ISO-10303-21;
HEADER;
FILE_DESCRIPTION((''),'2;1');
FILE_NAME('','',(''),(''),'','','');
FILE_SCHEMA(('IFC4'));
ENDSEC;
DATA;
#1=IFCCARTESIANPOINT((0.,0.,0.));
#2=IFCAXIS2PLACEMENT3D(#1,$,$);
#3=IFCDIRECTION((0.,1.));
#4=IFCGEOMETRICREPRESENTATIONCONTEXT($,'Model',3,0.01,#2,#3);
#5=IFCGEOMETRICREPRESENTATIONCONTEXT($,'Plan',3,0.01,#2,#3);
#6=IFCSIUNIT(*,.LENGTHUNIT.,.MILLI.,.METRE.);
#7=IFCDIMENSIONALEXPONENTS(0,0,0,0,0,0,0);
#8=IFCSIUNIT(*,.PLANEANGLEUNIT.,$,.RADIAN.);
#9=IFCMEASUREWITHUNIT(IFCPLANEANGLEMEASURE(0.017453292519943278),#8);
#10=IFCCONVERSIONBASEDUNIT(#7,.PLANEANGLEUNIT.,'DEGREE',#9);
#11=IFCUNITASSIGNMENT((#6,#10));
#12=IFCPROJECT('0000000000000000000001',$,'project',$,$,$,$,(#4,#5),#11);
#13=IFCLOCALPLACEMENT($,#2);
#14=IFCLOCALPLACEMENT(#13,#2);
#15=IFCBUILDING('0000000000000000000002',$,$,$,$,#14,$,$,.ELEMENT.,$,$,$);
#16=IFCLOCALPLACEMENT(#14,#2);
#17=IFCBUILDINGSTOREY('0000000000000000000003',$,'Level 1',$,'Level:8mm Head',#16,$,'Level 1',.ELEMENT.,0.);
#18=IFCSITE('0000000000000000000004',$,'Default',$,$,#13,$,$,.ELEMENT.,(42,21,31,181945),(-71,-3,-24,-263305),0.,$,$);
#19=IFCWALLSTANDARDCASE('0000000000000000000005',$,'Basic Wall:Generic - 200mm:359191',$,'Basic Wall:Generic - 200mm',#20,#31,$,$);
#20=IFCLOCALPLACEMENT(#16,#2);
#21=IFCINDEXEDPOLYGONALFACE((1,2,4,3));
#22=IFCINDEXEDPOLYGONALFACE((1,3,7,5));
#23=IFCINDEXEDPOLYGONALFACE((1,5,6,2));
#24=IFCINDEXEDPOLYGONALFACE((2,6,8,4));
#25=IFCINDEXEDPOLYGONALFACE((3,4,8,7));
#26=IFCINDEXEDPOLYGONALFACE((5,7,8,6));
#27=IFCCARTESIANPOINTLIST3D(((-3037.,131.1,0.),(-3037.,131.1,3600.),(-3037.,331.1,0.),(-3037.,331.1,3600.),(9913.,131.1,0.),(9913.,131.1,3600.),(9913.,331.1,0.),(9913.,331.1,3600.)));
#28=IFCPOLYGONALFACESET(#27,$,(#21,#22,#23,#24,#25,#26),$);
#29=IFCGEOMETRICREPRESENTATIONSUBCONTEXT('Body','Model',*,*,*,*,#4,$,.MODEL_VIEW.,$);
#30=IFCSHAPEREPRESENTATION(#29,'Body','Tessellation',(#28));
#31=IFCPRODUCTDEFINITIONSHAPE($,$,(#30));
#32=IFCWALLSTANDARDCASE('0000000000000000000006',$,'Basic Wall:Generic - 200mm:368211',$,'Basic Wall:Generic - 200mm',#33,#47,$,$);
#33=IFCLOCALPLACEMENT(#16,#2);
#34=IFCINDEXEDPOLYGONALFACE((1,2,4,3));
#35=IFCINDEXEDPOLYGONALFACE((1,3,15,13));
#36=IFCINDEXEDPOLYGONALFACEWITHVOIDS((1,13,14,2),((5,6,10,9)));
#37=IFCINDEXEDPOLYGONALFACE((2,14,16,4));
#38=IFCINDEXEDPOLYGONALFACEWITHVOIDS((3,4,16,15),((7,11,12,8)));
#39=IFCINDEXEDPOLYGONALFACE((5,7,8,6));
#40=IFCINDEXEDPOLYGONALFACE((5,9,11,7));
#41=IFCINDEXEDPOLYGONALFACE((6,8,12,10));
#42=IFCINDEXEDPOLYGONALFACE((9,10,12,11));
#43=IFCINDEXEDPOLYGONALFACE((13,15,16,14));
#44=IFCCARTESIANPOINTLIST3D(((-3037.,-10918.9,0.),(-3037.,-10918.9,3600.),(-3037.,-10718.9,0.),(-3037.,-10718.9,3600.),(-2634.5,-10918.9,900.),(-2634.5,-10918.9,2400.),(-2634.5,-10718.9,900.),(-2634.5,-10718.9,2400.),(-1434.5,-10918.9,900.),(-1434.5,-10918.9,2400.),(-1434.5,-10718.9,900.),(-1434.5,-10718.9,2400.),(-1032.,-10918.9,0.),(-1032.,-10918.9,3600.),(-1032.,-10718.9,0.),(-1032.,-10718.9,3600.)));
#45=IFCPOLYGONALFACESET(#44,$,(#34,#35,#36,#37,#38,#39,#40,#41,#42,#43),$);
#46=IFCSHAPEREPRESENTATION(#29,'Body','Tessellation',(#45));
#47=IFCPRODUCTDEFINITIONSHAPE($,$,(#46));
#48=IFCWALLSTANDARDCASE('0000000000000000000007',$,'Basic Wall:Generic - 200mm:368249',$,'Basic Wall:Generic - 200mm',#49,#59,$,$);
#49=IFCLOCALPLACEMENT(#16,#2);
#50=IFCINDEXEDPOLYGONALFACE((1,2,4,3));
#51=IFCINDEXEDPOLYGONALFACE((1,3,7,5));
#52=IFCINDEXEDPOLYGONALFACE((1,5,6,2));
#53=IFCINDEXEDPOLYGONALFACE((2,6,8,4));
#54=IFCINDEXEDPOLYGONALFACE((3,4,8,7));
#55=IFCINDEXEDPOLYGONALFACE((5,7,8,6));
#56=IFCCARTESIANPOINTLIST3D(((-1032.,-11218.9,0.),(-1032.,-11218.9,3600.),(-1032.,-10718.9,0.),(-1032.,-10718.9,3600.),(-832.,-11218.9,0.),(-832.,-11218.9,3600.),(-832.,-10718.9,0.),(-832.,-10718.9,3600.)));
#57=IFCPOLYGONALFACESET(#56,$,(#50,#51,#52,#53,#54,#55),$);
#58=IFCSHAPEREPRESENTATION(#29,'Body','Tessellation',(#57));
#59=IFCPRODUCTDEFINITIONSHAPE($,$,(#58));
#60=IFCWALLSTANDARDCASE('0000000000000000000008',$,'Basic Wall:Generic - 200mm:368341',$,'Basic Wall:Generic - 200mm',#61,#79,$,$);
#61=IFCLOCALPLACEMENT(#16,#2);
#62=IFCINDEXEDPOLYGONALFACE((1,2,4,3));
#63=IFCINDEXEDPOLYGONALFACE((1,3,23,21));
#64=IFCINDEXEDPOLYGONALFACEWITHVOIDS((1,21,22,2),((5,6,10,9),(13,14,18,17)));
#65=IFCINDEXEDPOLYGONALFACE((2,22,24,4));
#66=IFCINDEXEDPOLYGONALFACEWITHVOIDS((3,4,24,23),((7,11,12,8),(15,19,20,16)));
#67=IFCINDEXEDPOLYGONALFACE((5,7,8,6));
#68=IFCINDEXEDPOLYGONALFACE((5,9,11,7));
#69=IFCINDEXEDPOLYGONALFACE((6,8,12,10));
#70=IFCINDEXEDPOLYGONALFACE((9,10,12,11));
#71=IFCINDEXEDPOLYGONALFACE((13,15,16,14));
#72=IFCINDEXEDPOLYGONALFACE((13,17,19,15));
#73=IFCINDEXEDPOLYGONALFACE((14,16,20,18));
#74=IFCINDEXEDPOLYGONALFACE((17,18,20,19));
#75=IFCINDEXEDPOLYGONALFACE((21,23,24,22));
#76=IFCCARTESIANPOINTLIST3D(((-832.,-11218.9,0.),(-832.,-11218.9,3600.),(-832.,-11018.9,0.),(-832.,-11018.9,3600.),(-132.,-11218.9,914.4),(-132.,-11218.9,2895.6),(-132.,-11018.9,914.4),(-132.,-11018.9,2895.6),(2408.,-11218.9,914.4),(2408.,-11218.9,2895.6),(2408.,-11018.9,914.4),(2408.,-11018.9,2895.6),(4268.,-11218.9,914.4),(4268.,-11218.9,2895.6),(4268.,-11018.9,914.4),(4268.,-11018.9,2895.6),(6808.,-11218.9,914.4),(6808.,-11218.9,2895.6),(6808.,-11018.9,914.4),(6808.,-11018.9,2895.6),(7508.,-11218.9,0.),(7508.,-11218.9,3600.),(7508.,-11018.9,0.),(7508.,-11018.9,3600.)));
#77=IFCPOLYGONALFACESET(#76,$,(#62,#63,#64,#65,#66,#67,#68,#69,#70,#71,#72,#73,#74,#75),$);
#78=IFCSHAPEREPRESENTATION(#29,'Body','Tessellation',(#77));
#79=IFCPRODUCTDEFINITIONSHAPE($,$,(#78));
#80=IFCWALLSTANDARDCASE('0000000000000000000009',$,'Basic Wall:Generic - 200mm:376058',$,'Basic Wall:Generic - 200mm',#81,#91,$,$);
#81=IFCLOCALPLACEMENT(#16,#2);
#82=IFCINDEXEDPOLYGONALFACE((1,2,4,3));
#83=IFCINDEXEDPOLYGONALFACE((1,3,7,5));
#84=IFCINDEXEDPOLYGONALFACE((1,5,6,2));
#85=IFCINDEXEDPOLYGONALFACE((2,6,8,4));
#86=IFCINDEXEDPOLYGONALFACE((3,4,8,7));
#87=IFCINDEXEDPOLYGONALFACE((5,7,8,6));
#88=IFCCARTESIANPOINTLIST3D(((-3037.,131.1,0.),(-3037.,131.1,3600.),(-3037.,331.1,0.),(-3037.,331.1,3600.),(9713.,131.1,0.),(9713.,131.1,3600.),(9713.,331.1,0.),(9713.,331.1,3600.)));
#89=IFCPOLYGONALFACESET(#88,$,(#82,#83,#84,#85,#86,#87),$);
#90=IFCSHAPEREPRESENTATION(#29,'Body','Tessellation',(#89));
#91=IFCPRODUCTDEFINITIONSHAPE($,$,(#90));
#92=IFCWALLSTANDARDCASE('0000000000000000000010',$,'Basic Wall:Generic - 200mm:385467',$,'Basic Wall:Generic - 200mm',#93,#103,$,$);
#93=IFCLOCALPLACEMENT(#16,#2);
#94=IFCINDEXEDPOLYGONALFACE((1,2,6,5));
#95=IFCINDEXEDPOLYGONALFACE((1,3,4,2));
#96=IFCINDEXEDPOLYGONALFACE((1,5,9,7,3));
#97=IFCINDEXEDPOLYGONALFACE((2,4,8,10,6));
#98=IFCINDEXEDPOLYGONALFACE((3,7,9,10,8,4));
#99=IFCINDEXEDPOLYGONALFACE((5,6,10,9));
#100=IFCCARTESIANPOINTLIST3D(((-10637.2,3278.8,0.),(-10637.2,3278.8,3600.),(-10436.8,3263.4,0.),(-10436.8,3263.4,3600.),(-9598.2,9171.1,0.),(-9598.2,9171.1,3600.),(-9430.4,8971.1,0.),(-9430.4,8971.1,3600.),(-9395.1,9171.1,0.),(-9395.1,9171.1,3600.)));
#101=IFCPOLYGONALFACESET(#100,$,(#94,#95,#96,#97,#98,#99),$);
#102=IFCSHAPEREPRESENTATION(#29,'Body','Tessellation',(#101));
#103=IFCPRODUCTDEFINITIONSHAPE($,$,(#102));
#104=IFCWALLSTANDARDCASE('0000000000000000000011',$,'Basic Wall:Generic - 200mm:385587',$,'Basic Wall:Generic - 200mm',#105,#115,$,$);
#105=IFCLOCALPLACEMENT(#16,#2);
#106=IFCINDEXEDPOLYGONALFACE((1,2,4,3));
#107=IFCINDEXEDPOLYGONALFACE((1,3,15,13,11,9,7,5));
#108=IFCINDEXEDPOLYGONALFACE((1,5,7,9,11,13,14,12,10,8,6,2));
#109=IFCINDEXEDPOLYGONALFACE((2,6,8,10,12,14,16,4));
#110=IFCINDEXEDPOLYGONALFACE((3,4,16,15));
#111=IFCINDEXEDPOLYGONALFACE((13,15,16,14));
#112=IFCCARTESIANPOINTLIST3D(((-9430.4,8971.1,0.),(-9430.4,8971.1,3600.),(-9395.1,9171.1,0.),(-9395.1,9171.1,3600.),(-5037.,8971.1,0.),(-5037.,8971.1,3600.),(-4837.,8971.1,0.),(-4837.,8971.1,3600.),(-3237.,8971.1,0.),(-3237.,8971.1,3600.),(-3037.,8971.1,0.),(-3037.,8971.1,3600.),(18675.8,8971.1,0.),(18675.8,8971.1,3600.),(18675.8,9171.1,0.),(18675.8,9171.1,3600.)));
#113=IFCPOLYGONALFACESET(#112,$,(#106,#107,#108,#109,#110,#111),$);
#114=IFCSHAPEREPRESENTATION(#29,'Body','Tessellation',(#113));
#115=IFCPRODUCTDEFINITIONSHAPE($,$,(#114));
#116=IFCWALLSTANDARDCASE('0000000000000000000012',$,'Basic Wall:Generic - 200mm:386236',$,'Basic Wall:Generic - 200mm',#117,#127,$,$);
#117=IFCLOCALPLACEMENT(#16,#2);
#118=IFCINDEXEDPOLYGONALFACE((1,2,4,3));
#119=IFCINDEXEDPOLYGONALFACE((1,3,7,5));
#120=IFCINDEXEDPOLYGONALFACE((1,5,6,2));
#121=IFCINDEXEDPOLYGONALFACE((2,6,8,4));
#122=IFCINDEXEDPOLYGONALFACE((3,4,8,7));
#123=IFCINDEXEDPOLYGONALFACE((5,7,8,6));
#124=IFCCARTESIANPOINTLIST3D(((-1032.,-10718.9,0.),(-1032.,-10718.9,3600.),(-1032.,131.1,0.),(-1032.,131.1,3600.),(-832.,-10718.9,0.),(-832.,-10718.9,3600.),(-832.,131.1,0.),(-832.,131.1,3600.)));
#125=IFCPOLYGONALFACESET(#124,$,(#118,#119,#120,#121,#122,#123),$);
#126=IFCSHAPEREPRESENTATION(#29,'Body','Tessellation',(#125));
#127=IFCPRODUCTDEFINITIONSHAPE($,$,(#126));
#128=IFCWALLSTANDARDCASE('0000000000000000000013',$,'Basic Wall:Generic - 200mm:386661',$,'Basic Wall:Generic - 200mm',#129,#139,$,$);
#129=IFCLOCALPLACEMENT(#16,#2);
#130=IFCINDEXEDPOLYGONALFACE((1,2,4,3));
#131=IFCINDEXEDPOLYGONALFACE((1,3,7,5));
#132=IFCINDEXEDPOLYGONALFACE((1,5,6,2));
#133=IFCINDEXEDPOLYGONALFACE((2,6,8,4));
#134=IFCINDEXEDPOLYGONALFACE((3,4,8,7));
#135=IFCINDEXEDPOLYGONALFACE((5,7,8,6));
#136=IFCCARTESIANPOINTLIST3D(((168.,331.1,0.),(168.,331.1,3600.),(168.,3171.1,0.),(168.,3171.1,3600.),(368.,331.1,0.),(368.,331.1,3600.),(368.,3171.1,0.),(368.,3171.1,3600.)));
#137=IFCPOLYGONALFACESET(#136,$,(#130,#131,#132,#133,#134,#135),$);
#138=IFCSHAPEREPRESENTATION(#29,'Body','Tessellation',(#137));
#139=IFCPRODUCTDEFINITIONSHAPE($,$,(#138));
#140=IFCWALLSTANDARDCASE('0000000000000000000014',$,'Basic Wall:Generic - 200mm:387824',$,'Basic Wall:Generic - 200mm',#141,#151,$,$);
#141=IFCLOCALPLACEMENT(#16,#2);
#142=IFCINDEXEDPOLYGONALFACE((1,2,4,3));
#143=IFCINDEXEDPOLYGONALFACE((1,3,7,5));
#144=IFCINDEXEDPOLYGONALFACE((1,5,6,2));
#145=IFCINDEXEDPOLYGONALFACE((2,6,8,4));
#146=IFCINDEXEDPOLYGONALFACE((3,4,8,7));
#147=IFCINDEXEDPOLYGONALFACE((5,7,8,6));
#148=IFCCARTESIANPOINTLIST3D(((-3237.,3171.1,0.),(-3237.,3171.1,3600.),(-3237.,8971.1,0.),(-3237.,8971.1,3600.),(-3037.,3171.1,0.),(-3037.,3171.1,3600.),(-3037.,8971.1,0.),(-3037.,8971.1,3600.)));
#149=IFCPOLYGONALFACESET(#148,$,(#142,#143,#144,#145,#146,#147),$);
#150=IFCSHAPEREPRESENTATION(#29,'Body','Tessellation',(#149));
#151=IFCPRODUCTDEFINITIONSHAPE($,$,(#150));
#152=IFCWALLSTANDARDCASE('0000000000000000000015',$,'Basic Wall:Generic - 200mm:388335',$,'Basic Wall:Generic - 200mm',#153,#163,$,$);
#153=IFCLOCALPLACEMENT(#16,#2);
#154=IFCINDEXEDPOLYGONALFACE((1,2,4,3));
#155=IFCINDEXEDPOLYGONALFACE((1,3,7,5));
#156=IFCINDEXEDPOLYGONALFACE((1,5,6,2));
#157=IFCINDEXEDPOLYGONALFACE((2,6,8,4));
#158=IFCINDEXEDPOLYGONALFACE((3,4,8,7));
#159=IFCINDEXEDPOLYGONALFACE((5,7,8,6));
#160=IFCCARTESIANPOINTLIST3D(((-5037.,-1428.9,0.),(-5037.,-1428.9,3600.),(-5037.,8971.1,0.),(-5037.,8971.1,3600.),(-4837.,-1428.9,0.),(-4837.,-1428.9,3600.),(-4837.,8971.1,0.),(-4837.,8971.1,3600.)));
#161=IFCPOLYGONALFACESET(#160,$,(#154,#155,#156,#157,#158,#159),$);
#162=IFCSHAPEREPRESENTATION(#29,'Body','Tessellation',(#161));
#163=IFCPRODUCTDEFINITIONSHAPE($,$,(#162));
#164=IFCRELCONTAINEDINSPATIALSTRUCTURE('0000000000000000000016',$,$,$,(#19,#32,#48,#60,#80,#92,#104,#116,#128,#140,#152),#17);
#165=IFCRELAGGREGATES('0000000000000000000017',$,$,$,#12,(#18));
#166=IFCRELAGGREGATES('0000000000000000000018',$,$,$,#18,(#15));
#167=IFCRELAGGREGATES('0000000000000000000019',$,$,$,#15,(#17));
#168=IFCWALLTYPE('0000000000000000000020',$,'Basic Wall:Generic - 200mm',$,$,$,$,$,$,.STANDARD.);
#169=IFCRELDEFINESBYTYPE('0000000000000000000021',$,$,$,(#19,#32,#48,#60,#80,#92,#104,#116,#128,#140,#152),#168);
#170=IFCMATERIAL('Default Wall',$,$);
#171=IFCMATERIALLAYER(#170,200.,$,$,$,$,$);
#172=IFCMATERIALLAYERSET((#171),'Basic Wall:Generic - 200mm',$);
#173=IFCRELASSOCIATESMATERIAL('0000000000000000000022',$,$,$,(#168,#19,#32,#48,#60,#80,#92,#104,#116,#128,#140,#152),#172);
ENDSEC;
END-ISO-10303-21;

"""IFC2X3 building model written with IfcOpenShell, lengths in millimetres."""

from ifc_helpers import new_model, entity, si_unit, converted_unit, direction, frame, frame_2d, origin, place, context, subcontext, project, spatial, polyline, rectangle, outline, extrude, material, layer, layer_set, layer_usage, type_object, element, save


model = new_model("IFC2X3")

# Units and contexts
model_context = context("Model", 3, precision=0.01, world=origin(), true_north=direction((0.0, 1.0)))
plan_context = context("Plan", 3, precision=0.01, world=origin(), true_north=direction((0.0, 1.0)))
body_context = subcontext(model_context, "Body", "Model", "MODEL_VIEW")
ifc_project = project(units=[si_unit("LENGTHUNIT", "METRE", prefix="MILLI"), converted_unit("PLANEANGLEUNIT", "DEGREE", entity("IfcPlaneAngleMeasure", 0.017453292519943278), si_unit("PLANEANGLEUNIT", "RADIAN"), dimensions=[0, 0, 0, 0, 0, 0, 0])], contexts=[model_context, plan_context])

# Site, building, storey
site_placement = place(None, origin())
site = spatial("IfcSite", under=ifc_project, at=site_placement, Name="Default", CompositionType="ELEMENT", RefLatitude=(42, 21, 31, 181945), RefLongitude=(-71, -3, -24, -263305), RefElevation=0.0)
building_placement = place(site_placement, origin())
building = spatial("IfcBuilding", under=site, at=building_placement, CompositionType="ELEMENT")
storey_placement = place(building_placement, origin())
storey = spatial("IfcBuildingStorey", under=building, at=storey_placement, Name="Level 1", ObjectType="Level:8mm Head", LongName="Level 1", CompositionType="ELEMENT", Elevation=0.0)

# Wall
ifc_material_1 = material(Name="Default Wall")
ifc_layer_1 = layer(ifc_material_1, 200.0)
ifc_layer_set_1 = layer_set([ifc_layer_1], Name="Basic Wall:Generic - 200mm")
ifc_layer_usage_1 = layer_usage(ifc_layer_set_1, "AXIS2", "NEGATIVE", 100.0)
wall_type = type_object("IfcWallType", Name="Basic Wall:Generic - 200mm", PredefinedType="STANDARD", material=ifc_layer_set_1)
wall_1_placement = place(storey_placement, frame((-3037.0, 231.1, 0.0)))
element("IfcWallStandardCase", 1, at=wall_1_placement, inside=storey, type_object=wall_type, material=ifc_layer_usage_1, Name="Basic Wall:Generic - 200mm:359191", ObjectType="Basic Wall:Generic - 200mm", context=body_context, shape_type="SweptSolid", body=[
    extrude(rectangle(XDim=12950.0, YDim=200.0, at=frame_2d((6475.0, 0.0), x_axis=(-1.0, 0.0))), origin(), (0.0, 0.0, 1.0), 3600.0),
])

# Wall, opening
ifc_layer_usage_2 = layer_usage(ifc_layer_set_1, "AXIS2", "NEGATIVE", 100.0)
wall_2_placement = place(storey_placement, frame((-3037.0, -10818.9, 0.0)))
wall_2 = element("IfcWallStandardCase", 2, at=wall_2_placement, inside=storey, type_object=wall_type, material=ifc_layer_usage_2, Name="Basic Wall:Generic - 200mm:368211", ObjectType="Basic Wall:Generic - 200mm", context=body_context, shape_type="SweptSolid", body=[
    extrude(rectangle(XDim=2005.0, YDim=200.0, at=frame_2d((1002.5, 0.0), x_axis=(-1.0, 0.0))), origin(), (0.0, 0.0, 1.0), 3600.0),
])
opening_1_placement = place(wall_2_placement, frame((1602.5, 100.0, 900.0)))
element("IfcOpeningElement", 3, at=opening_1_placement, cuts=wall_2, ObjectType="Opening", context=body_context, shape_type="SweptSolid", body=[
    extrude(rectangle(XDim=1500.0, YDim=1200.0, at=frame_2d((750.0, 600.0), x_axis=(-1.0, 0.0))), frame((0.0, 0.0, 0.0), z_axis=(0.0, -1.0, 0.0), x_axis=(0.0, 0.0, 1.0)), (0.0, 0.0, 1.0), 200.0),
])

# Wall
ifc_layer_usage_3 = layer_usage(ifc_layer_set_1, "AXIS2", "NEGATIVE", 100.0)
wall_3_placement = place(storey_placement, frame((-932.0, -10718.9, 0.0), z_axis=(0.0, 0.0, 1.0), x_axis=(0.0, -1.0, 0.0)))
element("IfcWallStandardCase", 4, at=wall_3_placement, inside=storey, type_object=wall_type, material=ifc_layer_usage_3, Name="Basic Wall:Generic - 200mm:368249", ObjectType="Basic Wall:Generic - 200mm", context=body_context, shape_type="SweptSolid", body=[
    extrude(rectangle(XDim=500.0, YDim=200.0, at=frame_2d((250.0, 0.0), x_axis=(-1.0, 0.0))), origin(), (0.0, 0.0, 1.0), 3600.0),
])

# Wall, openings
ifc_layer_usage_4 = layer_usage(ifc_layer_set_1, "AXIS2", "NEGATIVE", 100.0)
wall_4_placement = place(storey_placement, frame((-832.0, -11118.9, 0.0)))
wall_4 = element("IfcWallStandardCase", 5, at=wall_4_placement, inside=storey, type_object=wall_type, material=ifc_layer_usage_4, Name="Basic Wall:Generic - 200mm:368341", ObjectType="Basic Wall:Generic - 200mm", context=body_context, shape_type="SweptSolid", body=[
    extrude(rectangle(XDim=8340.0, YDim=200.0, at=frame_2d((4170.0, 0.0), x_axis=(-1.0, 0.0))), origin(), (0.0, 0.0, 1.0), 3600.0),
])
opening_2_placement = place(wall_4_placement, frame((3240.0, 100.0, 914.4)))
element("IfcOpeningElement", 6, at=opening_2_placement, cuts=wall_4, ObjectType="Opening", context=body_context, shape_type="SweptSolid", body=[
    extrude(rectangle(XDim=1981.2, YDim=2540.0, at=frame_2d((990.6, 1270.0), x_axis=(-1.0, 0.0))), frame((0.0, 0.0, 0.0), z_axis=(0.0, -1.0, 0.0), x_axis=(0.0, 0.0, 1.0)), (0.0, 0.0, 1.0), 200.0),
])
opening_3_placement = place(wall_4_placement, frame((7640.0, 100.0, 914.4)))
element("IfcOpeningElement", 7, at=opening_3_placement, cuts=wall_4, ObjectType="Opening", context=body_context, shape_type="SweptSolid", body=[
    extrude(rectangle(XDim=1981.2, YDim=2540.0, at=frame_2d((990.6, 1270.0), x_axis=(-1.0, 0.0))), frame((0.0, 0.0, 0.0), z_axis=(0.0, -1.0, 0.0), x_axis=(0.0, 0.0, 1.0)), (0.0, 0.0, 1.0), 200.0),
])

# Walls
ifc_layer_usage_5 = layer_usage(ifc_layer_set_1, "AXIS2", "NEGATIVE", 100.0)
wall_5_placement = place(storey_placement, frame((-3037.0, 231.1, 0.0)))
element("IfcWallStandardCase", 8, at=wall_5_placement, inside=storey, type_object=wall_type, material=ifc_layer_usage_5, Name="Basic Wall:Generic - 200mm:376058", ObjectType="Basic Wall:Generic - 200mm", context=body_context, shape_type="SweptSolid", body=[
    extrude(rectangle(XDim=12750.0, YDim=200.0, at=frame_2d((6375.0, 0.0), x_axis=(-1.0, 0.0))), origin(), (0.0, 0.0, 1.0), 3600.0),
])
ifc_layer_usage_6 = layer_usage(ifc_layer_set_1, "AXIS2", "NEGATIVE", 100.0)
wall_6_placement = place(storey_placement, frame((-10538.7, 3261.4, 0.0), z_axis=(0.0, 0.0, 1.0), x_axis=(0.173648, 0.984808, 0.0)))
element("IfcWallStandardCase", 9, at=wall_6_placement, inside=storey, type_object=wall_type, material=ifc_layer_usage_6, Name="Basic Wall:Generic - 200mm:385467", ObjectType="Basic Wall:Generic - 200mm", context=body_context, shape_type="SweptSolid", body=[
    extrude(outline(polyline([(6018.5, -100.0), (5983.2, 100.0), (0.0, 100.0), (19.7, -100.0), (5815.4, -100.0), (6018.5, -100.0)])), origin(), (0.0, 0.0, 1.0), 3600.0),
])
ifc_layer_usage_7 = layer_usage(ifc_layer_set_1, "AXIS2", "NEGATIVE", 100.0)
wall_7_placement = place(storey_placement, frame((-9430.4, 9071.1, 0.0)))
element("IfcWallStandardCase", 10, at=wall_7_placement, inside=storey, type_object=wall_type, material=ifc_layer_usage_7, Name="Basic Wall:Generic - 200mm:385587", ObjectType="Basic Wall:Generic - 200mm", context=body_context, shape_type="SweptSolid", body=[
    extrude(outline(polyline([(28106.2, -100.0), (28106.2, 100.0), (35.3, 100.0), (0.0, -100.0), (4393.4, -100.0), (4593.4, -100.0), (6193.4, -100.0), (6393.4, -100.0), (28106.2, -100.0)])), origin(), (0.0, 0.0, 1.0), 3600.0),
])
ifc_layer_usage_8 = layer_usage(ifc_layer_set_1, "AXIS2", "NEGATIVE", 100.0)
wall_8_placement = place(storey_placement, frame((-932.0, 131.1, 0.0), z_axis=(0.0, 0.0, 1.0), x_axis=(0.0, -1.0, 0.0)))
element("IfcWallStandardCase", 11, at=wall_8_placement, inside=storey, type_object=wall_type, material=ifc_layer_usage_8, Name="Basic Wall:Generic - 200mm:386236", ObjectType="Basic Wall:Generic - 200mm", context=body_context, shape_type="SweptSolid", body=[
    extrude(rectangle(XDim=10850.0, YDim=200.0, at=frame_2d((5425.0, 0.0), x_axis=(-1.0, 0.0))), origin(), (0.0, 0.0, 1.0), 3600.0),
])
ifc_layer_usage_9 = layer_usage(ifc_layer_set_1, "AXIS2", "NEGATIVE", 100.0)
wall_9_placement = place(storey_placement, frame((268.0, 331.1, 0.0), z_axis=(0.0, 0.0, 1.0), x_axis=(0.0, 1.0, 0.0)))
element("IfcWallStandardCase", 12, at=wall_9_placement, inside=storey, type_object=wall_type, material=ifc_layer_usage_9, Name="Basic Wall:Generic - 200mm:386661", ObjectType="Basic Wall:Generic - 200mm", context=body_context, shape_type="SweptSolid", body=[
    extrude(rectangle(XDim=2840.0, YDim=200.0, at=frame_2d((1420.0, 0.0), x_axis=(-1.0, 0.0))), origin(), (0.0, 0.0, 1.0), 3600.0),
])
ifc_layer_usage_10 = layer_usage(ifc_layer_set_1, "AXIS2", "NEGATIVE", 100.0)
wall_10_placement = place(storey_placement, frame((-3137.0, 3171.1, 0.0), z_axis=(0.0, 0.0, 1.0), x_axis=(0.0, 1.0, 0.0)))
element("IfcWallStandardCase", 13, at=wall_10_placement, inside=storey, type_object=wall_type, material=ifc_layer_usage_10, Name="Basic Wall:Generic - 200mm:387824", ObjectType="Basic Wall:Generic - 200mm", context=body_context, shape_type="SweptSolid", body=[
    extrude(rectangle(XDim=5800.0, YDim=200.0, at=frame_2d((2900.0, 0.0), x_axis=(-1.0, 0.0))), origin(), (0.0, 0.0, 1.0), 3600.0),
])
ifc_layer_usage_11 = layer_usage(ifc_layer_set_1, "AXIS2", "NEGATIVE", 100.0)
wall_11_placement = place(storey_placement, frame((-4937.0, 8971.1, 0.0), z_axis=(0.0, 0.0, 1.0), x_axis=(0.0, -1.0, 0.0)))
element("IfcWallStandardCase", 14, at=wall_11_placement, inside=storey, type_object=wall_type, material=ifc_layer_usage_11, Name="Basic Wall:Generic - 200mm:388335", ObjectType="Basic Wall:Generic - 200mm", context=body_context, shape_type="SweptSolid", body=[
    extrude(rectangle(XDim=10400.0, YDim=200.0, at=frame_2d((5200.0, 0.0), x_axis=(-1.0, 0.0))), origin(), (0.0, 0.0, 1.0), 3600.0),
])

save(model, "model.ifc")
